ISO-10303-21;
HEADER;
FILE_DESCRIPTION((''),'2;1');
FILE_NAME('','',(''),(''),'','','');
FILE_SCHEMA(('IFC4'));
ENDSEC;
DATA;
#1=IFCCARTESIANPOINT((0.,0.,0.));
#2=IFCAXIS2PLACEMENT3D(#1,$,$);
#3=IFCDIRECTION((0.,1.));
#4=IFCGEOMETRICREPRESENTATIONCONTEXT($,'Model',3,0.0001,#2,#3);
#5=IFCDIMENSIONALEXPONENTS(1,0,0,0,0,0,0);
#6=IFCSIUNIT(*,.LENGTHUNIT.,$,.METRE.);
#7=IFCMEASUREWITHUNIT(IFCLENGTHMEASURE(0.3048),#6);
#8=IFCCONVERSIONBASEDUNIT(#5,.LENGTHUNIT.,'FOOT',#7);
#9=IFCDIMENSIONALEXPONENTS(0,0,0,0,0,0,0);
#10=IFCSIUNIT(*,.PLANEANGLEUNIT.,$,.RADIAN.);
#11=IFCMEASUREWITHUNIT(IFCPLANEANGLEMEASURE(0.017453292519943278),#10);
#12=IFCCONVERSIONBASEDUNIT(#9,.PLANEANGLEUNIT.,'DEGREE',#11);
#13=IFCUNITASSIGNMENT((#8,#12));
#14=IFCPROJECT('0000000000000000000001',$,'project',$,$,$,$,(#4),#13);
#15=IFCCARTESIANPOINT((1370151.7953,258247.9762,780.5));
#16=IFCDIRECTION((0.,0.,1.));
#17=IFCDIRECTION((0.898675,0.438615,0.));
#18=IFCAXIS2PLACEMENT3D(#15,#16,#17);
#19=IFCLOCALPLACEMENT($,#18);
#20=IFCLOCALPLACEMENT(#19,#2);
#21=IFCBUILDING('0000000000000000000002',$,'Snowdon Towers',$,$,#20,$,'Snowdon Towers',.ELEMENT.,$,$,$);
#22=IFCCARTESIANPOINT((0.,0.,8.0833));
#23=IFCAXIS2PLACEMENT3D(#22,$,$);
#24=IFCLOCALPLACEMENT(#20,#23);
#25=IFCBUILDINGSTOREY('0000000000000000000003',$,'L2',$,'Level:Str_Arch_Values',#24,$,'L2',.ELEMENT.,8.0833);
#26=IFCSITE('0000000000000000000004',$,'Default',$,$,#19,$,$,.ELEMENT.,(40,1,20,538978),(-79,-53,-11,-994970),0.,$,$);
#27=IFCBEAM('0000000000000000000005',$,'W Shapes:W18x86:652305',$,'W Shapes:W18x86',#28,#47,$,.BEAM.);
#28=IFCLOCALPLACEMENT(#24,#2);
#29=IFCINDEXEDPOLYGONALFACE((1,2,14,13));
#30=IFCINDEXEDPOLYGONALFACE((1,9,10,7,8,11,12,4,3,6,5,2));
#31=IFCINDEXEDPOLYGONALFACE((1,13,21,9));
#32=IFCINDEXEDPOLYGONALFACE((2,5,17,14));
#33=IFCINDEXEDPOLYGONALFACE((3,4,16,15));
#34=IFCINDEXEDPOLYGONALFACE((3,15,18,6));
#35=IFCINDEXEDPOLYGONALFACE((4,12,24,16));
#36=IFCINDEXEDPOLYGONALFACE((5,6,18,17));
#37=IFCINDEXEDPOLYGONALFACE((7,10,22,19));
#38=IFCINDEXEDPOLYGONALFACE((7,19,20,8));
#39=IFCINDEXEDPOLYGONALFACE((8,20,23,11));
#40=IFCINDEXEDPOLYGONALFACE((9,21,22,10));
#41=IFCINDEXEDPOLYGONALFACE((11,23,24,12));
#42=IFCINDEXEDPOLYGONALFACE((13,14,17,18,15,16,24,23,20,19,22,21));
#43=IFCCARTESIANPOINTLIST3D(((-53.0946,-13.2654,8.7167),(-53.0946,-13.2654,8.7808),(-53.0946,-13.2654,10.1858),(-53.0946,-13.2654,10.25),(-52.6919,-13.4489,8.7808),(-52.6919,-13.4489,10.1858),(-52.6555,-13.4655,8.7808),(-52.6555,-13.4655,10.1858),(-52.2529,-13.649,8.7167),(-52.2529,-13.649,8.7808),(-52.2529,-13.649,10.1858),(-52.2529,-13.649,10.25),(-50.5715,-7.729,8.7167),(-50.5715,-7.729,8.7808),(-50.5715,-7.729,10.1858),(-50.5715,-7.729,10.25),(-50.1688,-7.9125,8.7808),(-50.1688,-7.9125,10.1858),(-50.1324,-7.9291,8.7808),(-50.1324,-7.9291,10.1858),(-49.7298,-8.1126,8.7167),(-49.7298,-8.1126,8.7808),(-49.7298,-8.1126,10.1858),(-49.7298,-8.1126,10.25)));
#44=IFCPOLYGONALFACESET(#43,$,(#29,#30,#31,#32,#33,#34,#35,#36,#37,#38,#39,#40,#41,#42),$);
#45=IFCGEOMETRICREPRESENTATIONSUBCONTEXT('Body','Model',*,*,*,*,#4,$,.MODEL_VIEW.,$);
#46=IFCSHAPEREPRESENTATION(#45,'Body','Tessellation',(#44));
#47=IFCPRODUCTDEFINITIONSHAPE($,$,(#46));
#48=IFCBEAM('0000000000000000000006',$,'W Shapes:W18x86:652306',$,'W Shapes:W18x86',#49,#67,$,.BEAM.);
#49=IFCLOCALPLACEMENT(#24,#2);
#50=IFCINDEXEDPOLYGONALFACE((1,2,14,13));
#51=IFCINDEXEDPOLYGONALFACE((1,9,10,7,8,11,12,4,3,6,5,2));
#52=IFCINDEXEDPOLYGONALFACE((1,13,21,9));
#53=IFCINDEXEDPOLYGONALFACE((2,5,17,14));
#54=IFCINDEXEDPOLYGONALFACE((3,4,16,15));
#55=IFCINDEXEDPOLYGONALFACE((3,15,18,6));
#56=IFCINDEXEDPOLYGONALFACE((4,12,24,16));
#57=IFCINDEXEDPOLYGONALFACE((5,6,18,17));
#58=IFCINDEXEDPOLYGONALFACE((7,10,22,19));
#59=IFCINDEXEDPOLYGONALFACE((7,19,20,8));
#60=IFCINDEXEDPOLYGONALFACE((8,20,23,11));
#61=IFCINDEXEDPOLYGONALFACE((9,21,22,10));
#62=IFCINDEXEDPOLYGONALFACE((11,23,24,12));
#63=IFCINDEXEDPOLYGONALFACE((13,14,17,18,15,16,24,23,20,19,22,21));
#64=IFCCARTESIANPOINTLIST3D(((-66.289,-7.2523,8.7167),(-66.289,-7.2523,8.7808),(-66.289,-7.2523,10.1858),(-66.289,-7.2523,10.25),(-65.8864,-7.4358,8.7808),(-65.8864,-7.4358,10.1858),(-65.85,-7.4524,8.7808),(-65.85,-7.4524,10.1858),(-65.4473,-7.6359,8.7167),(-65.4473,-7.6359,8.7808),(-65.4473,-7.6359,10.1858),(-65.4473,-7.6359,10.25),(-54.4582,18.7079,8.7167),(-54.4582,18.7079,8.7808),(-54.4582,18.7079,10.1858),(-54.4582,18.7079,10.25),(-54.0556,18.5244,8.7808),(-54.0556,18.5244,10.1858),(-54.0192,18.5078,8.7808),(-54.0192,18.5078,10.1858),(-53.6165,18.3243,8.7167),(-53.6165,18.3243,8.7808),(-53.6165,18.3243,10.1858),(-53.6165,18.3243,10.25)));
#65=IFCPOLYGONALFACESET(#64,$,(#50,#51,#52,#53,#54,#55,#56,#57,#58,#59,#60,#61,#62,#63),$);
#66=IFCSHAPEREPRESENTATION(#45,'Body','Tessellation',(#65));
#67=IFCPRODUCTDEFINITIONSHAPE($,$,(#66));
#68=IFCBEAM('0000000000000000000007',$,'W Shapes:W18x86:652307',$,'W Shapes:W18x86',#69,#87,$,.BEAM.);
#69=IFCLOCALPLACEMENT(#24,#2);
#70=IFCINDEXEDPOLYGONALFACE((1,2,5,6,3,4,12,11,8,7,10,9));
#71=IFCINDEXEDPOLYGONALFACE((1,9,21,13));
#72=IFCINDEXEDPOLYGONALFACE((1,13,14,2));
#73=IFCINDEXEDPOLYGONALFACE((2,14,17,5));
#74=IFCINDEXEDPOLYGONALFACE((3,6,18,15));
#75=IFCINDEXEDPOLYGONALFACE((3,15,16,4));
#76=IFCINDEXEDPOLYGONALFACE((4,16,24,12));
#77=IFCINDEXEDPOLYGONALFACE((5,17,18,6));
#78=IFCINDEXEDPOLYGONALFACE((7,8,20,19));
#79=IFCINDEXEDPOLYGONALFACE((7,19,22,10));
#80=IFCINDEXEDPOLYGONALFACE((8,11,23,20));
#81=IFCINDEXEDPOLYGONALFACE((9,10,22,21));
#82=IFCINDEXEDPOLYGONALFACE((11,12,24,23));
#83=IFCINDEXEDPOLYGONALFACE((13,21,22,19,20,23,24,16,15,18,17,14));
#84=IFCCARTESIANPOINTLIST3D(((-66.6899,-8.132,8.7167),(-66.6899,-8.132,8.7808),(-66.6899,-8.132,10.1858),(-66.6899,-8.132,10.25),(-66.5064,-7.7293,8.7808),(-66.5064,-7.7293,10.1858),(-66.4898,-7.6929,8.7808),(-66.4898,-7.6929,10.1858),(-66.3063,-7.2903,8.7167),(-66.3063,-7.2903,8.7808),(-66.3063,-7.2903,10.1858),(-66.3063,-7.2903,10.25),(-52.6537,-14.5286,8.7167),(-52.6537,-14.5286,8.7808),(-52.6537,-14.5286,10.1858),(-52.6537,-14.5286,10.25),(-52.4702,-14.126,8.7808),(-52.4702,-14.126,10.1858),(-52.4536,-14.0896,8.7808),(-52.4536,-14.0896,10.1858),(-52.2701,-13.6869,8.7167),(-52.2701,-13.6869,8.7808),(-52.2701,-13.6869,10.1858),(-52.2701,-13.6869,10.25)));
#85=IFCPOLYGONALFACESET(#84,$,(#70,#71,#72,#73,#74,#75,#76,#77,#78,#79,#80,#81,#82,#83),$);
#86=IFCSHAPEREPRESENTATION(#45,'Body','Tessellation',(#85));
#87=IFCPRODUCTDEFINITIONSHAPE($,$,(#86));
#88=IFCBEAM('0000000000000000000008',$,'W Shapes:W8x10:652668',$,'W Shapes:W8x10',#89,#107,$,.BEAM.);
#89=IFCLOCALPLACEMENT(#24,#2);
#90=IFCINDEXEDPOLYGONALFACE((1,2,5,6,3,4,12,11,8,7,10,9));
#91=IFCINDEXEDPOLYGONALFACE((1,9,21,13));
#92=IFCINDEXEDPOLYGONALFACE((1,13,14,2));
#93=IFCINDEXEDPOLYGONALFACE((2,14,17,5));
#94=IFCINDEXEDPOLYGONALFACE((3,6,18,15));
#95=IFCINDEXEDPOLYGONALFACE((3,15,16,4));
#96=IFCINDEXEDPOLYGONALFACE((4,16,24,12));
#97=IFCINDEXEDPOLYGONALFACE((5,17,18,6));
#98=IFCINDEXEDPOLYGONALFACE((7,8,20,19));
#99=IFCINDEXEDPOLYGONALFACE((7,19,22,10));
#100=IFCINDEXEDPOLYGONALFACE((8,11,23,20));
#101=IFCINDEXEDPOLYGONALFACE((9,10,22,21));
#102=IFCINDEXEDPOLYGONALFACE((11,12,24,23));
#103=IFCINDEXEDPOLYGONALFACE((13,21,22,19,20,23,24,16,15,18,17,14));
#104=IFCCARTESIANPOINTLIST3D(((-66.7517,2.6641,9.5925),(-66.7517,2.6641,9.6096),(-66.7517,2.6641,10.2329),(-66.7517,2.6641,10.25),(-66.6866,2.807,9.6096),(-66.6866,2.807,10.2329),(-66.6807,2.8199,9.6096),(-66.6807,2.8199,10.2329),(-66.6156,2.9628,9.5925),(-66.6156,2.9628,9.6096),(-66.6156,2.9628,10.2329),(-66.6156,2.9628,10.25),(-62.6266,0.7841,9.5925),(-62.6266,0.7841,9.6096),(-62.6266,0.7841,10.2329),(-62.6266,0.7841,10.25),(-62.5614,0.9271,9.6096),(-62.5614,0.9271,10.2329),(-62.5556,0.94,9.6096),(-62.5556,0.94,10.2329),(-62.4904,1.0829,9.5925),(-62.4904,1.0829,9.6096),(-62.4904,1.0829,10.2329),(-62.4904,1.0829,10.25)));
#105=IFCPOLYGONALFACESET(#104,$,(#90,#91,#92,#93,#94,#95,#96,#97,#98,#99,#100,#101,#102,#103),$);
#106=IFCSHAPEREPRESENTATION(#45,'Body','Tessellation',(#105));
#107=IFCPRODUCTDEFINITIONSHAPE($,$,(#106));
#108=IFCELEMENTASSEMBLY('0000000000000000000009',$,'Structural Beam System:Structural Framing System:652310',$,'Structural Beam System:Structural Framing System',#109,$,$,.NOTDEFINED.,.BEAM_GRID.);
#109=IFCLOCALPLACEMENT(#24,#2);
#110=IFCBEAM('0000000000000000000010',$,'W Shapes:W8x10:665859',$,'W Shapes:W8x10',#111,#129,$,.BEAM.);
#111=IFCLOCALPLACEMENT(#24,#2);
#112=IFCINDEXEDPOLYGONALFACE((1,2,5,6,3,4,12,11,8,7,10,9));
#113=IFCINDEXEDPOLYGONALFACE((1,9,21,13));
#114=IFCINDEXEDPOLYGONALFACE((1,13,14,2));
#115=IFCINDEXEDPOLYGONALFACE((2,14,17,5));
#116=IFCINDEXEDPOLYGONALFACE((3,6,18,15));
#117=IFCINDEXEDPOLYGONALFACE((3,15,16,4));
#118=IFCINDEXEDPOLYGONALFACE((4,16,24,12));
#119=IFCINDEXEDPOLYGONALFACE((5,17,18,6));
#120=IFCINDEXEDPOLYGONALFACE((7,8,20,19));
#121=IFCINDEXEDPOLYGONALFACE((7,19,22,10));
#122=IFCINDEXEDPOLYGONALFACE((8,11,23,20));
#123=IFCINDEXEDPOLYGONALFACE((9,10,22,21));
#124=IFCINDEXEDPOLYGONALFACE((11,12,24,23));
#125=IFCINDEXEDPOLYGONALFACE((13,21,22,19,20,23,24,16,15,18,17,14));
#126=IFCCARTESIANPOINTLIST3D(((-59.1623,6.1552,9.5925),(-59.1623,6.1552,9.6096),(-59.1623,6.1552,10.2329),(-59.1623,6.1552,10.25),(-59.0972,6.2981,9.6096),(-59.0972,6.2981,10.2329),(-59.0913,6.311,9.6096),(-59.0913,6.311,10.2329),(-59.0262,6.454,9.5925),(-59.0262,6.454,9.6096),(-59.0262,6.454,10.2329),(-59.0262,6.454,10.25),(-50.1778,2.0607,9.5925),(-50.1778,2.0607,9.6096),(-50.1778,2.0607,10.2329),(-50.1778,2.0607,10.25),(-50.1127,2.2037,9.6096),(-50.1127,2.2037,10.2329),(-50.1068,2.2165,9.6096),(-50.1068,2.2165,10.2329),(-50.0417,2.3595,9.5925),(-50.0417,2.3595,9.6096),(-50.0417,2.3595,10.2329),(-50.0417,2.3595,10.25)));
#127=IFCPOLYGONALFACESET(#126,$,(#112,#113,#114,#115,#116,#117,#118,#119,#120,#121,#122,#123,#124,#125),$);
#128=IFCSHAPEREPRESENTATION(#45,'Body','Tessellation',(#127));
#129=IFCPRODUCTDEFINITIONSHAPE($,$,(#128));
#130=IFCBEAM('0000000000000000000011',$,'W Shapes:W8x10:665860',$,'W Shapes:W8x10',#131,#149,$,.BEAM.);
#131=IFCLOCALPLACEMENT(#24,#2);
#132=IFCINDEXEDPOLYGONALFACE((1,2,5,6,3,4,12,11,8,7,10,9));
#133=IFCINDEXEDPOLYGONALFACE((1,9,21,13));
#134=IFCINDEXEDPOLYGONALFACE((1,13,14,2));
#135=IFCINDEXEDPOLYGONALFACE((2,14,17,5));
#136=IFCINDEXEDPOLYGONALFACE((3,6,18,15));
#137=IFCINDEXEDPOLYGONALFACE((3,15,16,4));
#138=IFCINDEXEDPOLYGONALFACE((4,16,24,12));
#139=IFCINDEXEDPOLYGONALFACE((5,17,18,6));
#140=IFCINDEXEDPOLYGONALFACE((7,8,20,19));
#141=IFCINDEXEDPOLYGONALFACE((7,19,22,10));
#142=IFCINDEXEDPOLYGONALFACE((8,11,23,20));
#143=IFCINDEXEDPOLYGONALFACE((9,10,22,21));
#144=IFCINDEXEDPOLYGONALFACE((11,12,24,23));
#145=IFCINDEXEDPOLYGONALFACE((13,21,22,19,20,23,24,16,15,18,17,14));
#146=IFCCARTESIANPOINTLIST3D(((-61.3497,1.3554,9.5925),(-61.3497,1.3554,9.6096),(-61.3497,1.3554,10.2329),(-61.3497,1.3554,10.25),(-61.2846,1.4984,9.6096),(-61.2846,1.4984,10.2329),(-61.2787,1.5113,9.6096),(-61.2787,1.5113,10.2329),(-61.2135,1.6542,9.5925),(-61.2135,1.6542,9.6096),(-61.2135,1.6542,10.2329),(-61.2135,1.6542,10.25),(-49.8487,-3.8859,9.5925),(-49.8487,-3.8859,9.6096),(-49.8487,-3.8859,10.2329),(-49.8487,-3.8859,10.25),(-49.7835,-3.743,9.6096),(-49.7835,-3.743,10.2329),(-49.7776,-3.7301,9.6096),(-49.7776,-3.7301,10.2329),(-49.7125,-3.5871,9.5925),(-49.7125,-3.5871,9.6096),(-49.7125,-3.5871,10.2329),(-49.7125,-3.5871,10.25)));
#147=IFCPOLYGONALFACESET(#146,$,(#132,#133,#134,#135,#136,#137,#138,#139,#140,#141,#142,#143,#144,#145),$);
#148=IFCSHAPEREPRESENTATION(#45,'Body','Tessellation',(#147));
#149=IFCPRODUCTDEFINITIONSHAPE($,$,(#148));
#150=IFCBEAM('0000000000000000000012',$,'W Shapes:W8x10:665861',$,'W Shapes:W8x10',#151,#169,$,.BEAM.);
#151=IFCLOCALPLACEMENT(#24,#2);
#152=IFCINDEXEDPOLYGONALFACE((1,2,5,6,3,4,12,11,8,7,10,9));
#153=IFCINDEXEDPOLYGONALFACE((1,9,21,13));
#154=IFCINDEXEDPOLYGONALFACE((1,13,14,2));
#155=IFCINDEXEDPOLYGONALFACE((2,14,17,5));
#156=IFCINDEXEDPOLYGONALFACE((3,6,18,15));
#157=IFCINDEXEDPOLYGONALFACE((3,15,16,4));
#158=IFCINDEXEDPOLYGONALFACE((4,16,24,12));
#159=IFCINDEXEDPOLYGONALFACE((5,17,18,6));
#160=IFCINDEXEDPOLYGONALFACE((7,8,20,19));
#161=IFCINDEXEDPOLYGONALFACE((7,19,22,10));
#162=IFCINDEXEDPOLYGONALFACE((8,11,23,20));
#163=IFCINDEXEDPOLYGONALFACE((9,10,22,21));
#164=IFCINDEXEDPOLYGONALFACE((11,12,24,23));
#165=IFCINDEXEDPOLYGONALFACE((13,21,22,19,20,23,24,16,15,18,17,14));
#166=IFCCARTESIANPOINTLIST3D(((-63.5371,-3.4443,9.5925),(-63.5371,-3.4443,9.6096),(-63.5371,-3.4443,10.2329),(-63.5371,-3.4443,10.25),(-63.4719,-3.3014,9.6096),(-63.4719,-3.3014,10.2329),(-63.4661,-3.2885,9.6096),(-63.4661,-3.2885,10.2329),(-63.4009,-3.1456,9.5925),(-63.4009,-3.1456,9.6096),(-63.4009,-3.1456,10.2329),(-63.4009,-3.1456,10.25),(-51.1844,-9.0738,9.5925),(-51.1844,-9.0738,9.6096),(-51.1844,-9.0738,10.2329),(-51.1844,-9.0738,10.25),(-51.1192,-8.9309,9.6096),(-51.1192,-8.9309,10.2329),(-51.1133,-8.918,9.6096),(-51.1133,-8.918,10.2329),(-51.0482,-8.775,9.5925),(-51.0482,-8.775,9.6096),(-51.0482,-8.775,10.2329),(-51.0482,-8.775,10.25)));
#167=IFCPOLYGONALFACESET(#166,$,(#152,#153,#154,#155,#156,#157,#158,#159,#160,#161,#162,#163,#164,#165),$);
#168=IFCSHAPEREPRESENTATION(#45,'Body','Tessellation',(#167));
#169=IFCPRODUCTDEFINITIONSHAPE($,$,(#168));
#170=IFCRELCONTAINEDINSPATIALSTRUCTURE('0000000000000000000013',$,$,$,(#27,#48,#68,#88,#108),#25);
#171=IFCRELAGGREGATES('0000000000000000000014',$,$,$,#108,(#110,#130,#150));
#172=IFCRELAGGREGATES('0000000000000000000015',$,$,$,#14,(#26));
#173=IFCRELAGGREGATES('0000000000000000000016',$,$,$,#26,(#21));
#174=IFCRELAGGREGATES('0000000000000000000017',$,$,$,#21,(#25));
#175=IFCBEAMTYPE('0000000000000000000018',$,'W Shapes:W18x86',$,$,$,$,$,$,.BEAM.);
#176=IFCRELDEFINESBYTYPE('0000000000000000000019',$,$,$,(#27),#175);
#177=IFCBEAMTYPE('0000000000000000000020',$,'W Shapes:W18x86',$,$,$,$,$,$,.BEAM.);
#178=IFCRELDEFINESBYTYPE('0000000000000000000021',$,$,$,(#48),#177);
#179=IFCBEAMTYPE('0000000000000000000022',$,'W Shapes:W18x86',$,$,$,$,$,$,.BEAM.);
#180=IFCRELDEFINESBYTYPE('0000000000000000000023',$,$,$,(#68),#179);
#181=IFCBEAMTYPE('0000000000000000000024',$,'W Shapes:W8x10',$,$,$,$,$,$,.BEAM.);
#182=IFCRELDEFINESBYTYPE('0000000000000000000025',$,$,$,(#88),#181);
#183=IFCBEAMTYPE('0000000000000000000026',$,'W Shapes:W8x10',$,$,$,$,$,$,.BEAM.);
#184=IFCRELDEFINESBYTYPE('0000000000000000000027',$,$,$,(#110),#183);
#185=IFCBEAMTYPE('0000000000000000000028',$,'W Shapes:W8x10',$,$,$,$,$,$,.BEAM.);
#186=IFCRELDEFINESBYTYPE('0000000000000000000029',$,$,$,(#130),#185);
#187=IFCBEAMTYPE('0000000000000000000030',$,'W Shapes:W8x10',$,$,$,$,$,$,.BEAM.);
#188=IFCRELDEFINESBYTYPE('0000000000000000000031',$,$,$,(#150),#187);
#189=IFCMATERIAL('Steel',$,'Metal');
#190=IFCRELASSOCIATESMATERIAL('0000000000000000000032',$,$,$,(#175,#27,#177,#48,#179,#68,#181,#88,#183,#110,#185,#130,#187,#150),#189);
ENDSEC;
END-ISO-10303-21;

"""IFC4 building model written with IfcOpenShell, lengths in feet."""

from ifc_helpers import new_model, entity, si_unit, converted_unit, direction, frame, origin, place, context, subcontext, project, spatial, indexed_curve, outline, extrude, source, transform, mapped, material, type_object, type_shapes, element, aggregate, save


model = new_model("IFC4")

# Units and contexts
model_context = context("Model", 3, precision=0.0001, world=origin(), true_north=direction((0.0, 1.0)))
body_context = subcontext(model_context, "Body", "Model", "MODEL_VIEW")
ifc_project = project(units=[converted_unit("LENGTHUNIT", "FOOT", entity("IfcLengthMeasure", 0.3048), si_unit("LENGTHUNIT", "METRE"), dimensions=[1, 0, 0, 0, 0, 0, 0]), converted_unit("PLANEANGLEUNIT", "DEGREE", entity("IfcPlaneAngleMeasure", 0.017453292519943278), si_unit("PLANEANGLEUNIT", "RADIAN"), dimensions=[0, 0, 0, 0, 0, 0, 0])], contexts=[model_context])

# Site, building, storey
site_placement = place(None, frame((1370151.7953, 258247.9762, 780.5), z_axis=(0.0, 0.0, 1.0), x_axis=(0.898675, 0.438615, 0.0)))
site = spatial("IfcSite", under=ifc_project, at=site_placement, Name="Default", CompositionType="ELEMENT", RefLatitude=(40, 1, 20, 538978), RefLongitude=(-79, -53, -11, -994970), RefElevation=0.0)
building_placement = place(site_placement, origin())
building = spatial("IfcBuilding", under=site, at=building_placement, Name="Snowdon Towers", LongName="Snowdon Towers", CompositionType="ELEMENT")
storey_placement = place(building_placement, frame((0.0, 0.0, 8.0833)))
storey = spatial("IfcBuildingStorey", under=building, at=storey_placement, Name="L2", ObjectType="Level:Str_Arch_Values", LongName="L2", CompositionType="ELEMENT", Elevation=8.0833)

# Shared definitions
ifc_material = material(Name="Steel", Category="Metal")

# Beams
beam_type_1 = type_object("IfcBeamType", Name="W Shapes:W18x86", PredefinedType="BEAM", material=ifc_material)
shared_shape_1 = source(origin(), body_context, "Body", "SweptSolid", [
    extrude(outline(indexed_curve([(-0.4625, -0.7025), (-0.4625, -0.7667), (0.4625, -0.7667), (0.4625, -0.7025), (0.02, -0.7025), (0.02, 0.7025), (0.4625, 0.7025), (0.4625, 0.7667), (-0.4625, 0.7667), (-0.4625, 0.7025), (-0.02, 0.7025), (-0.02, -0.7025), (-0.4625, -0.7025)], self_intersect=False)), frame((-3.8759, 0.0, 0.0), z_axis=(-1.0, 0.0, 0.0), x_axis=(0.0, -1.0, 0.0)), (0.0, 0.0, -1.0), 6.0842),
])
type_shapes(beam_type_1, [shared_shape_1])
beam_1_placement = place(storey_placement, frame((-51.0664, -9.9302, 9.4833), z_axis=(0.0, 0.0, 1.0), x_axis=(0.414693, 0.909961, 0.0)))
element("IfcBeam", 1, at=beam_1_placement, inside=storey, type_object=beam_type_1, material=ifc_material, Name="W Shapes:W18x86:652305", ObjectType="W Shapes:W18x86", PredefinedType="BEAM", context=body_context, shape_type="MappedRepresentation", body=[
    mapped(shared_shape_1, transform((0.0, 0.0, 0.0), scale=1.0)),
])
beam_type_2 = type_object("IfcBeamType", Name="W Shapes:W18x86", PredefinedType="BEAM", material=ifc_material)
shared_shape_2 = source(origin(), body_context, "Body", "SweptSolid", [
    extrude(outline(indexed_curve([(-0.4625, -0.7025), (-0.4625, -0.7667), (0.4625, -0.7667), (0.4625, -0.7025), (0.02, -0.7025), (0.02, 0.7025), (0.4625, 0.7025), (0.4625, 0.7667), (-0.4625, 0.7667), (-0.4625, 0.7025), (-0.02, 0.7025), (-0.02, -0.7025), (-0.4625, -0.7025)], self_intersect=False)), frame((-14.3928, 0.0, 0.0), z_axis=(-1.0, 0.0, 0.0), x_axis=(0.0, -1.0, 0.0)), (0.0, 0.0, -1.0), 28.529),
])
type_shapes(beam_type_2, [shared_shape_2])
beam_2_placement = place(storey_placement, frame((-59.8996, 5.6527, 9.4833), z_axis=(0.0, 0.0, 1.0), x_axis=(0.414693, 0.909961, 0.0)))
element("IfcBeam", 2, at=beam_2_placement, inside=storey, type_object=beam_type_2, material=ifc_material, Name="W Shapes:W18x86:652306", ObjectType="W Shapes:W18x86", PredefinedType="BEAM", context=body_context, shape_type="MappedRepresentation", body=[
    mapped(shared_shape_2, transform((0.0, 0.0, 0.0), scale=1.0)),
])
beam_type_3 = type_object("IfcBeamType", Name="W Shapes:W18x86", PredefinedType="BEAM", material=ifc_material)
shared_shape_3 = source(origin(), body_context, "Body", "SweptSolid", [
    extrude(outline(indexed_curve([(-0.4625, -0.7025), (-0.4625, -0.7667), (0.4625, -0.7667), (0.4625, -0.7025), (0.02, -0.7025), (0.02, 0.7025), (0.4625, 0.7025), (0.4625, 0.7667), (-0.4625, 0.7667), (-0.4625, 0.7025), (-0.02, 0.7025), (-0.02, -0.7025), (-0.4625, -0.7025)], self_intersect=False)), frame((-7.7125, 0.0, 0.0), z_axis=(-1.0, 0.0, 0.0), x_axis=(0.0, -1.0, 0.0)), (0.0, 0.0, -1.0), 15.425),
])
type_shapes(beam_type_3, [shared_shape_3])
beam_3_placement = place(storey_placement, frame((-59.48, -10.9094, 9.4833), z_axis=(0.0, 0.0, 1.0), x_axis=(0.909961, -0.414693, 0.0)))
element("IfcBeam", 3, at=beam_3_placement, inside=storey, type_object=beam_type_3, material=ifc_material, Name="W Shapes:W18x86:652307", ObjectType="W Shapes:W18x86", PredefinedType="BEAM", context=body_context, shape_type="MappedRepresentation", body=[
    mapped(shared_shape_3, transform((0.0, 0.0, 0.0), scale=1.0)),
])
beam_type_4 = type_object("IfcBeamType", Name="W Shapes:W8x10", PredefinedType="BEAM", material=ifc_material)
shared_shape_4 = source(origin(), body_context, "Body", "SweptSolid", [
    extrude(outline(indexed_curve([(-0.1642, -0.3117), (-0.1642, -0.3288), (0.1642, -0.3288), (0.1642, -0.3117), (0.0071, -0.3117), (0.0071, 0.3117), (0.1642, 0.3117), (0.1642, 0.3287), (-0.1642, 0.3287), (-0.1642, 0.3117), (-0.0071, 0.3117), (-0.0071, -0.3117), (-0.1642, -0.3117)], self_intersect=False)), frame((-2.2667, 0.0, 0.0), z_axis=(-1.0, 0.0, 0.0), x_axis=(0.0, -1.0, 0.0)), (0.0, 0.0, -1.0), 4.5333),
])
type_shapes(beam_type_4, [shared_shape_4])
beam_4_placement = place(storey_placement, frame((-64.6211, 1.8735, 9.9213), z_axis=(0.0, 0.0, 1.0), x_axis=(-0.909961, 0.414693, 0.0)))
element("IfcBeam", 4, at=beam_4_placement, inside=storey, type_object=beam_type_4, material=ifc_material, Name="W Shapes:W8x10:652668", ObjectType="W Shapes:W8x10", PredefinedType="BEAM", context=body_context, shape_type="MappedRepresentation", body=[
    mapped(shared_shape_4, transform((0.0, 0.0, 0.0), scale=1.0)),
])

# Element assembly, beams
assembly_1_placement = place(storey_placement, origin())
assembly_1 = element("IfcElementAssembly", 5, at=assembly_1_placement, inside=storey, Name="Structural Beam System:Structural Framing System:652310", ObjectType="Structural Beam System:Structural Framing System", AssemblyPlace="NOTDEFINED", PredefinedType="BEAM_GRID")
beam_type_5 = type_object("IfcBeamType", Name="W Shapes:W8x10", PredefinedType="BEAM", material=ifc_material)
shared_shape_5 = source(origin(), body_context, "Body", "SweptSolid", [
    extrude(outline(indexed_curve([(-0.1642, -0.3117), (-0.1642, -0.3288), (0.1642, -0.3288), (0.1642, -0.3117), (0.0071, -0.3117), (0.0071, 0.3117), (0.1642, 0.3117), (0.1642, 0.3287), (-0.1642, 0.3287), (-0.1642, 0.3117), (-0.0071, 0.3117), (-0.0071, -0.3117), (-0.1642, -0.3117)], self_intersect=False)), frame((-5.0366, 0.0, 0.0), z_axis=(-1.0, 0.0, 0.0), x_axis=(0.0, -1.0, 0.0)), (0.0, 0.0, -1.0), 9.8735),
])
type_shapes(beam_type_5, [shared_shape_5])
beam_5_placement = place(assembly_1_placement, frame((-54.5112, 4.2159, 9.9213), z_axis=(0.0, 0.0, 1.0), x_axis=(0.909961, -0.414693, 0.0)))
beam_5 = element("IfcBeam", 6, at=beam_5_placement, type_object=beam_type_5, material=ifc_material, Name="W Shapes:W8x10:665859", ObjectType="W Shapes:W8x10", PredefinedType="BEAM", context=body_context, shape_type="MappedRepresentation", body=[
    mapped(shared_shape_5, transform((0.0, 0.0, 0.0), scale=1.0)),
])
beam_type_6 = type_object("IfcBeamType", Name="W Shapes:W8x10", PredefinedType="BEAM", material=ifc_material)
shared_shape_6 = source(origin(), body_context, "Body", "SweptSolid", [
    extrude(outline(indexed_curve([(-0.1642, -0.3117), (-0.1642, -0.3288), (0.1642, -0.3288), (0.1642, -0.3117), (0.0071, -0.3117), (0.0071, 0.3117), (0.1642, 0.3117), (0.1642, 0.3287), (-0.1642, 0.3287), (-0.1642, 0.3117), (-0.0071, 0.3117), (-0.0071, -0.3117), (-0.1642, -0.3117)], self_intersect=False)), frame((-6.3798, 0.0, 0.0), z_axis=(-1.0, 0.0, 0.0), x_axis=(0.0, -1.0, 0.0)), (0.0, 0.0, -1.0), 12.6391),
])
type_shapes(beam_type_6, [shared_shape_6])
beam_6_placement = place(assembly_1_placement, frame((-55.4762, -1.1409, 9.9213), z_axis=(0.0, 0.0, 1.0), x_axis=(0.909961, -0.414693, 0.0)))
beam_6 = element("IfcBeam", 7, at=beam_6_placement, type_object=beam_type_6, material=ifc_material, Name="W Shapes:W8x10:665860", ObjectType="W Shapes:W8x10", PredefinedType="BEAM", context=body_context, shape_type="MappedRepresentation", body=[
    mapped(shared_shape_6, transform((0.0, 0.0, 0.0), scale=1.0)),
])
beam_type_7 = type_object("IfcBeamType", Name="W Shapes:W8x10", PredefinedType="BEAM", material=ifc_material)
shared_shape_7 = source(origin(), body_context, "Body", "SweptSolid", [
    extrude(outline(indexed_curve([(-0.1642, -0.3117), (-0.1642, -0.3288), (0.1642, -0.3288), (0.1642, -0.3117), (0.0071, -0.3117), (0.0071, 0.3117), (0.1642, 0.3117), (0.1642, 0.3287), (-0.1642, 0.3287), (-0.1642, 0.3117), (-0.0071, 0.3117), (-0.0071, -0.3117), (-0.1642, -0.3117)], self_intersect=False)), frame((-6.7875, 0.0, 0.0), z_axis=(-1.0, 0.0, 0.0), x_axis=(0.0, -1.0, 0.0)), (0.0, 0.0, -1.0), 13.575),
])
type_shapes(beam_type_7, [shared_shape_7])
beam_7_placement = place(assembly_1_placement, frame((-57.2926, -6.1097, 9.9213), z_axis=(0.0, 0.0, 1.0), x_axis=(0.909961, -0.414693, 0.0)))
beam_7 = element("IfcBeam", 8, at=beam_7_placement, type_object=beam_type_7, material=ifc_material, Name="W Shapes:W8x10:665861", ObjectType="W Shapes:W8x10", PredefinedType="BEAM", context=body_context, shape_type="MappedRepresentation", body=[
    mapped(shared_shape_7, transform((0.0, 0.0, 0.0), scale=1.0)),
])
aggregate(assembly_1, [beam_5, beam_6, beam_7])

save(model, "model.ifc")
